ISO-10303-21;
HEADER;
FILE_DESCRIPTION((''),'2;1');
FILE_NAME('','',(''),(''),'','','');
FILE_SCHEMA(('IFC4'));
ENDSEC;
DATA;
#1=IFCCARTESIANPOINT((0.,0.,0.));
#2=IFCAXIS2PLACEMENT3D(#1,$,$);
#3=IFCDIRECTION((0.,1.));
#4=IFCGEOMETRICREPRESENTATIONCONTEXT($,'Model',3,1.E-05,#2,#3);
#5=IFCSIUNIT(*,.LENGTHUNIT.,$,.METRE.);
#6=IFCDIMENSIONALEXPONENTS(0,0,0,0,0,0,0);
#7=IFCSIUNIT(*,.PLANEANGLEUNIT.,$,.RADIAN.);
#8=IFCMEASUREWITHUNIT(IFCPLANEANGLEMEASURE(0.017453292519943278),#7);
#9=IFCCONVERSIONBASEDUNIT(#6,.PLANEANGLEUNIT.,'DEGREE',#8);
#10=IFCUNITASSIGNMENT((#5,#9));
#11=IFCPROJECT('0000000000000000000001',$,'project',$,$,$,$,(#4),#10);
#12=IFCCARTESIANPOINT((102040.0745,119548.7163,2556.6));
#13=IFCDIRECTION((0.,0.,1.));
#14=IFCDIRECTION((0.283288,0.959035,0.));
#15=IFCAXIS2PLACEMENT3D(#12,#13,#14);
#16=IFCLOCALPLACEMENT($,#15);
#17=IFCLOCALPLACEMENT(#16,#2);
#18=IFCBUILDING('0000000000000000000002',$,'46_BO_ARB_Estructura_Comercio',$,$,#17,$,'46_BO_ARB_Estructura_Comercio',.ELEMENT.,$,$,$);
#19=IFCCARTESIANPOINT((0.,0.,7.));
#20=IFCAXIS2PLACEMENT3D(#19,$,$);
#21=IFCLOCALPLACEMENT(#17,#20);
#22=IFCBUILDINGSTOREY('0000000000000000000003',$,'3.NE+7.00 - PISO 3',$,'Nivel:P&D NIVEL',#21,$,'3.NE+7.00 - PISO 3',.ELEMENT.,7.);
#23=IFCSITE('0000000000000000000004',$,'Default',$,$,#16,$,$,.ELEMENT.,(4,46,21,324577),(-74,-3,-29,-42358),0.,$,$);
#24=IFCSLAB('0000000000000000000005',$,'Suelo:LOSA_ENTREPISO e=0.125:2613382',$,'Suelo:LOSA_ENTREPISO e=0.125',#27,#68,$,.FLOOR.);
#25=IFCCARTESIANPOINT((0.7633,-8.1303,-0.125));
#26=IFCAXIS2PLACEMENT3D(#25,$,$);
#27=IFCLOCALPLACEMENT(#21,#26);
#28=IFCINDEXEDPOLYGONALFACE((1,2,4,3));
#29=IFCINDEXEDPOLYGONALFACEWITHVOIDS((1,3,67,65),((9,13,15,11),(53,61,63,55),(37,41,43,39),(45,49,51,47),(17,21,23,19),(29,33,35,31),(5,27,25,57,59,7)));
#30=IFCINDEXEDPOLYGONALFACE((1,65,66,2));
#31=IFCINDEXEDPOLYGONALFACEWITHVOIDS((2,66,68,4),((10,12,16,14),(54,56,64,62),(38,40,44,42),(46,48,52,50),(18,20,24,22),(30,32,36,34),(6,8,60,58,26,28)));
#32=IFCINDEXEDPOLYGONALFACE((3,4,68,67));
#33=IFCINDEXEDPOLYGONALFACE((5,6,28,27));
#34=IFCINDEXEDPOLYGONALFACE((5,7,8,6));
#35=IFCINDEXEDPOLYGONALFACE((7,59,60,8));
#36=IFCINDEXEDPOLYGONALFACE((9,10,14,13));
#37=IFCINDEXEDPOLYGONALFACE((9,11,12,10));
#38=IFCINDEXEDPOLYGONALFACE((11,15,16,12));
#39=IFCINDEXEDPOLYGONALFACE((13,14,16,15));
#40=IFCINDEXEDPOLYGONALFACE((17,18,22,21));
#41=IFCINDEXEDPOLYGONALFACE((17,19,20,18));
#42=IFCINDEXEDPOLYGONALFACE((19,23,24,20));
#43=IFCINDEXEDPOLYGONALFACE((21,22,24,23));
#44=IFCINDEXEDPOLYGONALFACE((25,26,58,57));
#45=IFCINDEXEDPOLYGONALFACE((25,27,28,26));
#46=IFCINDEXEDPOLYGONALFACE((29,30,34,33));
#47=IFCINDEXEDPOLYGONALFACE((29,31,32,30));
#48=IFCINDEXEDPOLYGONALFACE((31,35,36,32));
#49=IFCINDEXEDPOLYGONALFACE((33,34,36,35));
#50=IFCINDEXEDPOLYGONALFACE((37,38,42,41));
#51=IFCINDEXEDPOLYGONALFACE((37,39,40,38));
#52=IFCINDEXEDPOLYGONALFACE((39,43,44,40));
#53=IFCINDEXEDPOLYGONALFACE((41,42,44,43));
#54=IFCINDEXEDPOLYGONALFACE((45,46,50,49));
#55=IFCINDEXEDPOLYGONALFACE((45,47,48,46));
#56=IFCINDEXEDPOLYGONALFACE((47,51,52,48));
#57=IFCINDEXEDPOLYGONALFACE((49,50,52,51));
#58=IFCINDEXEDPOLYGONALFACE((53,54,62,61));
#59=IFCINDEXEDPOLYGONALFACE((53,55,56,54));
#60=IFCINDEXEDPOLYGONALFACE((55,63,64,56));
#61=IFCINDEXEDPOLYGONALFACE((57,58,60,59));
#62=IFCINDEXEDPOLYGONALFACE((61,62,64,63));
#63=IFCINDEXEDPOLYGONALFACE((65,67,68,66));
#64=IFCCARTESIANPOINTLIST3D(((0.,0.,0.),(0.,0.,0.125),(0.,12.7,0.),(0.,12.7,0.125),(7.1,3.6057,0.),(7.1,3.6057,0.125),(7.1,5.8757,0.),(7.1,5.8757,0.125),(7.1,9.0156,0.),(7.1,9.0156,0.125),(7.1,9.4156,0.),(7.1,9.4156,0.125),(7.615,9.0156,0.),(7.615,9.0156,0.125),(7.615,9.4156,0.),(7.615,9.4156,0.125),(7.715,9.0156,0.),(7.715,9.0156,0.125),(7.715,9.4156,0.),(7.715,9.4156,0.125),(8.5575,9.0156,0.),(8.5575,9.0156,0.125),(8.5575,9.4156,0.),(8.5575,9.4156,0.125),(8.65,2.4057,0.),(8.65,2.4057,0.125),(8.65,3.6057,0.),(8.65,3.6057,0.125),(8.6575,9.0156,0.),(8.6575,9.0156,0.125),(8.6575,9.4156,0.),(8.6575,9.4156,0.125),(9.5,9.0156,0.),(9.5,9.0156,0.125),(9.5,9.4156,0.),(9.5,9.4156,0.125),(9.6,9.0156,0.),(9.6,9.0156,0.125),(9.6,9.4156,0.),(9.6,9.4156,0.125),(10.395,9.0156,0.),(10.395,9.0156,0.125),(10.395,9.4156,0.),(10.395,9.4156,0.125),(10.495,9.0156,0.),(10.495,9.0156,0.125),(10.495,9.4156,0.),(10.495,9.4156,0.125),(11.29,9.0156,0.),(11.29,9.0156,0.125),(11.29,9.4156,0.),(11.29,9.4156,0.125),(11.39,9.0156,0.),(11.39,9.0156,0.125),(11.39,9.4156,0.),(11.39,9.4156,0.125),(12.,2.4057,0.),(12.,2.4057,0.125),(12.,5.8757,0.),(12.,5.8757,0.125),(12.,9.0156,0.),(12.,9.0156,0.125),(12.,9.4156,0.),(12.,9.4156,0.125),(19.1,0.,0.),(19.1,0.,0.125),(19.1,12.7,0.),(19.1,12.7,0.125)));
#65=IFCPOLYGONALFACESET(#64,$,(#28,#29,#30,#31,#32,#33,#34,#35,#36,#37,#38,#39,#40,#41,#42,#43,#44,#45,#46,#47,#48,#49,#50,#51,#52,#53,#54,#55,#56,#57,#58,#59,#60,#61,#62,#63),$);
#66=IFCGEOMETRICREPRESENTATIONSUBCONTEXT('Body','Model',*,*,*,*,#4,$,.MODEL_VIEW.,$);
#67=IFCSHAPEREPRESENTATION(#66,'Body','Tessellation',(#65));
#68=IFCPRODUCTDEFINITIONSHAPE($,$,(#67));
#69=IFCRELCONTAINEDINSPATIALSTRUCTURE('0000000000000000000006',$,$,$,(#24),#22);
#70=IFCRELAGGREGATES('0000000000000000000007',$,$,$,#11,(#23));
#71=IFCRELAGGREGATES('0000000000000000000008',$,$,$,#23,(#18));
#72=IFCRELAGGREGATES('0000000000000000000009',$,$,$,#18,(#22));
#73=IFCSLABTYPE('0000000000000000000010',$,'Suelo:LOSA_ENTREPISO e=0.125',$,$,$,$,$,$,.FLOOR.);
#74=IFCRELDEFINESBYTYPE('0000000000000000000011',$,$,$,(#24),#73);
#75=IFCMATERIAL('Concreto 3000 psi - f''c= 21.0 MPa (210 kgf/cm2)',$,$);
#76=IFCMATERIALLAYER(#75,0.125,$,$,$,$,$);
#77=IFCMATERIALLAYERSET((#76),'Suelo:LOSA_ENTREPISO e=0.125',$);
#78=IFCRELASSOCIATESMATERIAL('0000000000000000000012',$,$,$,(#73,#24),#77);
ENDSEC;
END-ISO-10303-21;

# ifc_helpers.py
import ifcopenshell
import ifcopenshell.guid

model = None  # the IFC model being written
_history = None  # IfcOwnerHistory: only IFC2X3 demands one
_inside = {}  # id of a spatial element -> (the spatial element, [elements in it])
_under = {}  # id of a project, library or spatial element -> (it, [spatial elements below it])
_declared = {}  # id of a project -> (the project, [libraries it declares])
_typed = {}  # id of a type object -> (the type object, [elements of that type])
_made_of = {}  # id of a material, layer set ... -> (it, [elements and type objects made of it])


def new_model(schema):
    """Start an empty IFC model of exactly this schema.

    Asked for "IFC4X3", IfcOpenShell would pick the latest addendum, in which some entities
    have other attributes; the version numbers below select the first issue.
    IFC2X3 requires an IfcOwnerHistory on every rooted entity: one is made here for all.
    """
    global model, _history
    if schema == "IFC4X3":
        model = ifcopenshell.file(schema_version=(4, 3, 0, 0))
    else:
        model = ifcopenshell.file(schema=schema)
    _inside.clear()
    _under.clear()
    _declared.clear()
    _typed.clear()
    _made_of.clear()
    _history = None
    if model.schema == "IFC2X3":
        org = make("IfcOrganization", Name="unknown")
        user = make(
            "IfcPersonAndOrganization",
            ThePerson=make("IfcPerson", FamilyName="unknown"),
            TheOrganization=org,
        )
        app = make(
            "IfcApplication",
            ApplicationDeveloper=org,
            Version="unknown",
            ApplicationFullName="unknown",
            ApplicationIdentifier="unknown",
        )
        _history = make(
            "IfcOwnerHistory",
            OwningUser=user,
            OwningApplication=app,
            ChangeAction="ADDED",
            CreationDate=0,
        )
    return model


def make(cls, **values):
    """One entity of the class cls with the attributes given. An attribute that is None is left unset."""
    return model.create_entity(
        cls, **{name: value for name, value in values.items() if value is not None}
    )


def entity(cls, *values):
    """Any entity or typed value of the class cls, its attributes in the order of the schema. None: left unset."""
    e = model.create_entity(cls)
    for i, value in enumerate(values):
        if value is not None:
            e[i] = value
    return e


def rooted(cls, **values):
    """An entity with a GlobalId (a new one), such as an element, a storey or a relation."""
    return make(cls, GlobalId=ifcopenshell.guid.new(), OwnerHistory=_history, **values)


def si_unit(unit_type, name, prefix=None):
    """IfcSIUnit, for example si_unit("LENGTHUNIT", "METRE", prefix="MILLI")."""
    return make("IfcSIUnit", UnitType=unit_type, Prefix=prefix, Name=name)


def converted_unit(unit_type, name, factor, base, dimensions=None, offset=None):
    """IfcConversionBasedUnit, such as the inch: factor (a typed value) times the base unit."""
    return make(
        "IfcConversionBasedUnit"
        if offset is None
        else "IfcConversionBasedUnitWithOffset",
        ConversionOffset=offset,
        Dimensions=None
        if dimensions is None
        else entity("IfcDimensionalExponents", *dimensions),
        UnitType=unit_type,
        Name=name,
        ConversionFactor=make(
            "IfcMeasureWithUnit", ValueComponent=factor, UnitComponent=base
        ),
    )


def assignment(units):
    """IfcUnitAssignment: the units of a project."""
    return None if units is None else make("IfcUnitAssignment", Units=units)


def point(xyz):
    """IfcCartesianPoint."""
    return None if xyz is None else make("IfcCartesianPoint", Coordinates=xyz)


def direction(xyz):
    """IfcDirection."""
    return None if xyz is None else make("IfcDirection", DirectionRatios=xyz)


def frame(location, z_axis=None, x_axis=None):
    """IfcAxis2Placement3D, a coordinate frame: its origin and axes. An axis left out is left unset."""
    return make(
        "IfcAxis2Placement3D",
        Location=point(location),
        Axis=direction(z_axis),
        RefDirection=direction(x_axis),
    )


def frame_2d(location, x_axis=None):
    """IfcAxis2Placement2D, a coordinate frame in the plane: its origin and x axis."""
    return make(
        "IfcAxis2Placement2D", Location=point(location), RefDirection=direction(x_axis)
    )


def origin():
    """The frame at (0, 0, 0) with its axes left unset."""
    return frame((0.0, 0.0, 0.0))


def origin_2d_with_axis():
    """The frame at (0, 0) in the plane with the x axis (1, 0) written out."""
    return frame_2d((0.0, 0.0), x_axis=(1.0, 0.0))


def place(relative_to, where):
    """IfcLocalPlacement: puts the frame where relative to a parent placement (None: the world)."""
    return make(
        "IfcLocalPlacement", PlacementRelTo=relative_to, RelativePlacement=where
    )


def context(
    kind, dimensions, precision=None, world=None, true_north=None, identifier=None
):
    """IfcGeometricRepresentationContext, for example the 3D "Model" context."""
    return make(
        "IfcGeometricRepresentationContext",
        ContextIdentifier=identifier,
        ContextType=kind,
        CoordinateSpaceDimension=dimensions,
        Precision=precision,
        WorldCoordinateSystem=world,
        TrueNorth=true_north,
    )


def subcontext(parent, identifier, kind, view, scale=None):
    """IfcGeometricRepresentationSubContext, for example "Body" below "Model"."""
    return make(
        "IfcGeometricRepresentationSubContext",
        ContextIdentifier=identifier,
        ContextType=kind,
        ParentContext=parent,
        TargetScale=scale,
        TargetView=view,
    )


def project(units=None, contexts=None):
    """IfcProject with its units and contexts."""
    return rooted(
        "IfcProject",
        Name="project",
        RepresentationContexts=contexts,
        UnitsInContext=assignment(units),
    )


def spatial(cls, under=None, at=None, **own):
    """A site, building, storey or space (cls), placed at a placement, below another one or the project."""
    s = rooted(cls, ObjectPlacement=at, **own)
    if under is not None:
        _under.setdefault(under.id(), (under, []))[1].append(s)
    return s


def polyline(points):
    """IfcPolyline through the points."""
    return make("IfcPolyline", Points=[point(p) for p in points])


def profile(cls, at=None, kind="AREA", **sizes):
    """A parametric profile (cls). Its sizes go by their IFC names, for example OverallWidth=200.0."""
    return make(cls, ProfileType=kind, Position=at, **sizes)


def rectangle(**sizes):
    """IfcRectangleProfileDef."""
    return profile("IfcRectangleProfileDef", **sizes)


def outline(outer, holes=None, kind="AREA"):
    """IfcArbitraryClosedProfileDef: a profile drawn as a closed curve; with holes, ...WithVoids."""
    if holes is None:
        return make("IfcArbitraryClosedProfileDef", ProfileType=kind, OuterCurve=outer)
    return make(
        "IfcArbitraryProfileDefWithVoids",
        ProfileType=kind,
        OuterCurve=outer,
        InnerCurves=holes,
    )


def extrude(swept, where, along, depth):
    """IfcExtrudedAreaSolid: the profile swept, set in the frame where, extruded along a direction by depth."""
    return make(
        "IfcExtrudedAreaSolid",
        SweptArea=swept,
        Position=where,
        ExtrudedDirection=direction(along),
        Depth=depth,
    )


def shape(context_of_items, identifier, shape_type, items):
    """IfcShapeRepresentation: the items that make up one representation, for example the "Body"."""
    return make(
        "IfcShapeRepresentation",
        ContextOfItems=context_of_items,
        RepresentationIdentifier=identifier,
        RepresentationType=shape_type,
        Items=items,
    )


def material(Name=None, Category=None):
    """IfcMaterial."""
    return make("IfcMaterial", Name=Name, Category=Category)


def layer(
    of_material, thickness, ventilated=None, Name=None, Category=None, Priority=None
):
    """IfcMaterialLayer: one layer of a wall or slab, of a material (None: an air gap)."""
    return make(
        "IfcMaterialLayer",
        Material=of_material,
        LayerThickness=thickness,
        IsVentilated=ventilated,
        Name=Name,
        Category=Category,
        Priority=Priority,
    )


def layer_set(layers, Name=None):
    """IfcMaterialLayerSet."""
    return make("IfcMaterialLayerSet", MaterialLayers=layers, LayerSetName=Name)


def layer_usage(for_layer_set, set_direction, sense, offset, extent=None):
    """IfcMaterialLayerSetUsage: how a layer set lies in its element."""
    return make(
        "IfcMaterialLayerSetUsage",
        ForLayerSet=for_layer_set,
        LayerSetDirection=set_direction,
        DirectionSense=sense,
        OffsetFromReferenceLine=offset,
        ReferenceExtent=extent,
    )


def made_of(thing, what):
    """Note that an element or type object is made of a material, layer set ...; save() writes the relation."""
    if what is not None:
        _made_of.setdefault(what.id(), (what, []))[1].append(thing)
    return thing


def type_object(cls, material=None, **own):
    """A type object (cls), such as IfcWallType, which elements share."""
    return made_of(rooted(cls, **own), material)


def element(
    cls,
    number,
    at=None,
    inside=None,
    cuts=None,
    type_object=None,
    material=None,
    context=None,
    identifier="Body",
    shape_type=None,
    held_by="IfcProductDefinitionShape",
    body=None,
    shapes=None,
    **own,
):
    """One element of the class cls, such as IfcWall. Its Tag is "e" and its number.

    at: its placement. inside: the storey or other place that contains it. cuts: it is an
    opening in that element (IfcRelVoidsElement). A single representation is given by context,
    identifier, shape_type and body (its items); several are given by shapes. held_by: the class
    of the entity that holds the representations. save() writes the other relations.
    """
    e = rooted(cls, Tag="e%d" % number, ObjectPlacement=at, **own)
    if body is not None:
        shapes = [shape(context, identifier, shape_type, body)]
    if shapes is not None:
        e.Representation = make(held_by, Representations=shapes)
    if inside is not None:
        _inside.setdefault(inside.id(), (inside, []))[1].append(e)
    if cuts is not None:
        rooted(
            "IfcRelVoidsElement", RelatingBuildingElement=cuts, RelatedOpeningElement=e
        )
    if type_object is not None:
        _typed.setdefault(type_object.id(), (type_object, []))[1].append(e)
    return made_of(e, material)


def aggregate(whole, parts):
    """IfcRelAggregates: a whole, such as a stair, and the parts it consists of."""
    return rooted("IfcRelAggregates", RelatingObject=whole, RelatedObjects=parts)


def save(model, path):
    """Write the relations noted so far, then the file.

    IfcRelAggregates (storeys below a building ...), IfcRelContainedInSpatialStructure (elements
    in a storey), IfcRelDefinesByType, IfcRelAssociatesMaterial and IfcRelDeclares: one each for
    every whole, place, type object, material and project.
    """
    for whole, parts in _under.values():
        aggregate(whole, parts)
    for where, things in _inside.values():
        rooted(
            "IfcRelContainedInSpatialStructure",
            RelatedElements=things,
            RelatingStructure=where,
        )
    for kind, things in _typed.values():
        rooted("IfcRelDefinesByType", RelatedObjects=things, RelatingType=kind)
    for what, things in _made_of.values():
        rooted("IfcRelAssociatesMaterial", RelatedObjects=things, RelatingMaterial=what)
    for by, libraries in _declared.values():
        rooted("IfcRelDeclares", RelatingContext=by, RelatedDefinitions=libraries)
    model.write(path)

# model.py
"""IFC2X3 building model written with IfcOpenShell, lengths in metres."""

from ifc_helpers import new_model, entity, si_unit, converted_unit, direction, frame, frame_2d, origin, origin_2d_with_axis, place, context, subcontext, project, spatial, polyline, rectangle, outline, extrude, material, layer, layer_set, layer_usage, type_object, element, save


model = new_model("IFC2X3")

# Units and contexts
model_context = context("Model", 3, precision=1e-05, world=origin(), true_north=direction((0.0, 1.0)))
body_context = subcontext(model_context, "Body", "Model", "MODEL_VIEW")
ifc_project = project(units=[si_unit("LENGTHUNIT", "METRE"), converted_unit("PLANEANGLEUNIT", "DEGREE", entity("IfcPlaneAngleMeasure", 0.017453292519943278), si_unit("PLANEANGLEUNIT", "RADIAN"), dimensions=[0, 0, 0, 0, 0, 0, 0])], contexts=[model_context])

# Site, building, storey
site_placement = place(None, frame((102040.0745, 119548.7163, 2556.6), z_axis=(0.0, 0.0, 1.0), x_axis=(0.283288, 0.959035, 0.0)))
site = spatial("IfcSite", under=ifc_project, at=site_placement, Name="Default", CompositionType="ELEMENT", RefLatitude=(4, 46, 21, 324577), RefLongitude=(-74, -3, -29, -42358), RefElevation=0.0)
building_placement = place(site_placement, origin())
building = spatial("IfcBuilding", under=site, at=building_placement, Name="46_BO_ARB_Estructura_Comercio", LongName="46_BO_ARB_Estructura_Comercio", CompositionType="ELEMENT")
storey_placement = place(building_placement, frame((0.0, 0.0, 7.0)))
storey = spatial("IfcBuildingStorey", under=building, at=storey_placement, Name="3.NE+7.00 - PISO 3", ObjectType="Nivel:P&D NIVEL", LongName="3.NE+7.00 - PISO 3", CompositionType="ELEMENT", Elevation=7.0)

# Shared definitions
ifc_material_1 = material(Name="Concreto 3000 psi - f'c= 21.0 MPa (210 kgf/cm2)")

# Slab, openings
ifc_layer = layer(ifc_material_1, 0.125)
ifc_layer_set = layer_set([ifc_layer], Name="Suelo:LOSA_ENTREPISO e=0.125")
ifc_layer_usage = layer_usage(ifc_layer_set, "AXIS3", "POSITIVE", 0.0)
slab_type = type_object("IfcSlabType", Name="Suelo:LOSA_ENTREPISO e=0.125", PredefinedType="FLOOR", material=ifc_layer_set)
slab_placement = place(storey_placement, frame((0.7633, -8.1303, -0.125)))
slab = element("IfcSlab", 1, at=slab_placement, inside=storey, type_object=slab_type, material=ifc_layer_usage, Name="Suelo:LOSA_ENTREPISO e=0.125:2613382", ObjectType="Suelo:LOSA_ENTREPISO e=0.125", PredefinedType="FLOOR", context=body_context, shape_type="SweptSolid", body=[
    extrude(rectangle(XDim=12.7, YDim=19.1, at=frame_2d((0.0, 0.0), x_axis=(0.0, -1.0))), frame((9.55, 6.35, 0.125), z_axis=(0.0, 0.0, -1.0), x_axis=(-1.0, 0.0, 0.0)), (0.0, 0.0, 1.0), 0.125),
])
opening_1_placement = place(slab_placement, origin())
element("IfcOpeningElement", 2, at=opening_1_placement, cuts=slab, ObjectType="Opening", context=body_context, shape_type="SweptSolid", body=[
    extrude(outline(polyline([(-1.9133, -2.75), (1.5567, -2.75), (1.5567, 0.6), (0.3567, 0.6), (0.3567, 2.15), (-1.9133, 2.15), (-1.9133, -2.75)])), frame((9.25, 3.9624, 0.125), z_axis=(0.0, 0.0, -1.0), x_axis=(0.0, -1.0, 0.0)), (0.0, 0.0, 1.0), 0.125),
])
opening_2_placement = place(slab_placement, origin())
element("IfcOpeningElement", 3, at=opening_2_placement, cuts=slab, ObjectType="Opening", context=body_context, shape_type="SweptSolid", body=[
    extrude(rectangle(XDim=0.515, YDim=0.4, at=origin_2d_with_axis()), frame((7.3575, 9.2156, 0.125), z_axis=(0.0, 0.0, -1.0), x_axis=(-1.0, 0.0, 0.0)), (0.0, 0.0, 1.0), 0.125),
])
opening_3_placement = place(slab_placement, origin())
element("IfcOpeningElement", 4, at=opening_3_placement, cuts=slab, ObjectType="Opening", context=body_context, shape_type="SweptSolid", body=[
    extrude(rectangle(XDim=0.4, YDim=0.8425, at=origin_2d_with_axis()), frame((8.1362, 9.2156, 0.125), z_axis=(0.0, 0.0, -1.0), x_axis=(0.0, -1.0, 0.0)), (0.0, 0.0, 1.0), 0.125),
])
opening_4_placement = place(slab_placement, origin())
element("IfcOpeningElement", 5, at=opening_4_placement, cuts=slab, ObjectType="Opening", context=body_context, shape_type="SweptSolid", body=[
    extrude(rectangle(XDim=0.4, YDim=0.8425, at=frame_2d((0.0, 0.0), x_axis=(1.0, 0.0))), frame((9.0787, 9.2156, 0.125), z_axis=(0.0, 0.0, -1.0), x_axis=(0.0, -1.0, 0.0)), (0.0, 0.0, 1.0), 0.125),
])
opening_5_placement = place(slab_placement, origin())
element("IfcOpeningElement", 6, at=opening_5_placement, cuts=slab, ObjectType="Opening", context=body_context, shape_type="SweptSolid", body=[
    extrude(rectangle(XDim=0.4, YDim=0.795, at=frame_2d((0.0, 0.0), x_axis=(1.0, 0.0))), frame((9.9975, 9.2156, 0.125), z_axis=(0.0, 0.0, -1.0), x_axis=(0.0, -1.0, 0.0)), (0.0, 0.0, 1.0), 0.125),
])
opening_6_placement = place(slab_placement, origin())
element("IfcOpeningElement", 7, at=opening_6_placement, cuts=slab, ObjectType="Opening", context=body_context, shape_type="SweptSolid", body=[
    extrude(rectangle(XDim=0.4, YDim=0.795, at=origin_2d_with_axis()), frame((10.8925, 9.2156, 0.125), z_axis=(0.0, 0.0, -1.0), x_axis=(0.0, -1.0, 0.0)), (0.0, 0.0, 1.0), 0.125),
])
opening_7_placement = place(slab_placement, origin())
element("IfcOpeningElement", 8, at=opening_7_placement, cuts=slab, ObjectType="Opening", context=body_context, shape_type="SweptSolid", body=[
    extrude(rectangle(XDim=0.4, YDim=0.61, at=frame_2d((0.0, 0.0), x_axis=(1.0, 0.0))), frame((11.695, 9.2156, 0.125), z_axis=(0.0, 0.0, -1.0), x_axis=(0.0, -1.0, 0.0)), (0.0, 0.0, 1.0), 0.125),
])

save(model, "model.ifc")
